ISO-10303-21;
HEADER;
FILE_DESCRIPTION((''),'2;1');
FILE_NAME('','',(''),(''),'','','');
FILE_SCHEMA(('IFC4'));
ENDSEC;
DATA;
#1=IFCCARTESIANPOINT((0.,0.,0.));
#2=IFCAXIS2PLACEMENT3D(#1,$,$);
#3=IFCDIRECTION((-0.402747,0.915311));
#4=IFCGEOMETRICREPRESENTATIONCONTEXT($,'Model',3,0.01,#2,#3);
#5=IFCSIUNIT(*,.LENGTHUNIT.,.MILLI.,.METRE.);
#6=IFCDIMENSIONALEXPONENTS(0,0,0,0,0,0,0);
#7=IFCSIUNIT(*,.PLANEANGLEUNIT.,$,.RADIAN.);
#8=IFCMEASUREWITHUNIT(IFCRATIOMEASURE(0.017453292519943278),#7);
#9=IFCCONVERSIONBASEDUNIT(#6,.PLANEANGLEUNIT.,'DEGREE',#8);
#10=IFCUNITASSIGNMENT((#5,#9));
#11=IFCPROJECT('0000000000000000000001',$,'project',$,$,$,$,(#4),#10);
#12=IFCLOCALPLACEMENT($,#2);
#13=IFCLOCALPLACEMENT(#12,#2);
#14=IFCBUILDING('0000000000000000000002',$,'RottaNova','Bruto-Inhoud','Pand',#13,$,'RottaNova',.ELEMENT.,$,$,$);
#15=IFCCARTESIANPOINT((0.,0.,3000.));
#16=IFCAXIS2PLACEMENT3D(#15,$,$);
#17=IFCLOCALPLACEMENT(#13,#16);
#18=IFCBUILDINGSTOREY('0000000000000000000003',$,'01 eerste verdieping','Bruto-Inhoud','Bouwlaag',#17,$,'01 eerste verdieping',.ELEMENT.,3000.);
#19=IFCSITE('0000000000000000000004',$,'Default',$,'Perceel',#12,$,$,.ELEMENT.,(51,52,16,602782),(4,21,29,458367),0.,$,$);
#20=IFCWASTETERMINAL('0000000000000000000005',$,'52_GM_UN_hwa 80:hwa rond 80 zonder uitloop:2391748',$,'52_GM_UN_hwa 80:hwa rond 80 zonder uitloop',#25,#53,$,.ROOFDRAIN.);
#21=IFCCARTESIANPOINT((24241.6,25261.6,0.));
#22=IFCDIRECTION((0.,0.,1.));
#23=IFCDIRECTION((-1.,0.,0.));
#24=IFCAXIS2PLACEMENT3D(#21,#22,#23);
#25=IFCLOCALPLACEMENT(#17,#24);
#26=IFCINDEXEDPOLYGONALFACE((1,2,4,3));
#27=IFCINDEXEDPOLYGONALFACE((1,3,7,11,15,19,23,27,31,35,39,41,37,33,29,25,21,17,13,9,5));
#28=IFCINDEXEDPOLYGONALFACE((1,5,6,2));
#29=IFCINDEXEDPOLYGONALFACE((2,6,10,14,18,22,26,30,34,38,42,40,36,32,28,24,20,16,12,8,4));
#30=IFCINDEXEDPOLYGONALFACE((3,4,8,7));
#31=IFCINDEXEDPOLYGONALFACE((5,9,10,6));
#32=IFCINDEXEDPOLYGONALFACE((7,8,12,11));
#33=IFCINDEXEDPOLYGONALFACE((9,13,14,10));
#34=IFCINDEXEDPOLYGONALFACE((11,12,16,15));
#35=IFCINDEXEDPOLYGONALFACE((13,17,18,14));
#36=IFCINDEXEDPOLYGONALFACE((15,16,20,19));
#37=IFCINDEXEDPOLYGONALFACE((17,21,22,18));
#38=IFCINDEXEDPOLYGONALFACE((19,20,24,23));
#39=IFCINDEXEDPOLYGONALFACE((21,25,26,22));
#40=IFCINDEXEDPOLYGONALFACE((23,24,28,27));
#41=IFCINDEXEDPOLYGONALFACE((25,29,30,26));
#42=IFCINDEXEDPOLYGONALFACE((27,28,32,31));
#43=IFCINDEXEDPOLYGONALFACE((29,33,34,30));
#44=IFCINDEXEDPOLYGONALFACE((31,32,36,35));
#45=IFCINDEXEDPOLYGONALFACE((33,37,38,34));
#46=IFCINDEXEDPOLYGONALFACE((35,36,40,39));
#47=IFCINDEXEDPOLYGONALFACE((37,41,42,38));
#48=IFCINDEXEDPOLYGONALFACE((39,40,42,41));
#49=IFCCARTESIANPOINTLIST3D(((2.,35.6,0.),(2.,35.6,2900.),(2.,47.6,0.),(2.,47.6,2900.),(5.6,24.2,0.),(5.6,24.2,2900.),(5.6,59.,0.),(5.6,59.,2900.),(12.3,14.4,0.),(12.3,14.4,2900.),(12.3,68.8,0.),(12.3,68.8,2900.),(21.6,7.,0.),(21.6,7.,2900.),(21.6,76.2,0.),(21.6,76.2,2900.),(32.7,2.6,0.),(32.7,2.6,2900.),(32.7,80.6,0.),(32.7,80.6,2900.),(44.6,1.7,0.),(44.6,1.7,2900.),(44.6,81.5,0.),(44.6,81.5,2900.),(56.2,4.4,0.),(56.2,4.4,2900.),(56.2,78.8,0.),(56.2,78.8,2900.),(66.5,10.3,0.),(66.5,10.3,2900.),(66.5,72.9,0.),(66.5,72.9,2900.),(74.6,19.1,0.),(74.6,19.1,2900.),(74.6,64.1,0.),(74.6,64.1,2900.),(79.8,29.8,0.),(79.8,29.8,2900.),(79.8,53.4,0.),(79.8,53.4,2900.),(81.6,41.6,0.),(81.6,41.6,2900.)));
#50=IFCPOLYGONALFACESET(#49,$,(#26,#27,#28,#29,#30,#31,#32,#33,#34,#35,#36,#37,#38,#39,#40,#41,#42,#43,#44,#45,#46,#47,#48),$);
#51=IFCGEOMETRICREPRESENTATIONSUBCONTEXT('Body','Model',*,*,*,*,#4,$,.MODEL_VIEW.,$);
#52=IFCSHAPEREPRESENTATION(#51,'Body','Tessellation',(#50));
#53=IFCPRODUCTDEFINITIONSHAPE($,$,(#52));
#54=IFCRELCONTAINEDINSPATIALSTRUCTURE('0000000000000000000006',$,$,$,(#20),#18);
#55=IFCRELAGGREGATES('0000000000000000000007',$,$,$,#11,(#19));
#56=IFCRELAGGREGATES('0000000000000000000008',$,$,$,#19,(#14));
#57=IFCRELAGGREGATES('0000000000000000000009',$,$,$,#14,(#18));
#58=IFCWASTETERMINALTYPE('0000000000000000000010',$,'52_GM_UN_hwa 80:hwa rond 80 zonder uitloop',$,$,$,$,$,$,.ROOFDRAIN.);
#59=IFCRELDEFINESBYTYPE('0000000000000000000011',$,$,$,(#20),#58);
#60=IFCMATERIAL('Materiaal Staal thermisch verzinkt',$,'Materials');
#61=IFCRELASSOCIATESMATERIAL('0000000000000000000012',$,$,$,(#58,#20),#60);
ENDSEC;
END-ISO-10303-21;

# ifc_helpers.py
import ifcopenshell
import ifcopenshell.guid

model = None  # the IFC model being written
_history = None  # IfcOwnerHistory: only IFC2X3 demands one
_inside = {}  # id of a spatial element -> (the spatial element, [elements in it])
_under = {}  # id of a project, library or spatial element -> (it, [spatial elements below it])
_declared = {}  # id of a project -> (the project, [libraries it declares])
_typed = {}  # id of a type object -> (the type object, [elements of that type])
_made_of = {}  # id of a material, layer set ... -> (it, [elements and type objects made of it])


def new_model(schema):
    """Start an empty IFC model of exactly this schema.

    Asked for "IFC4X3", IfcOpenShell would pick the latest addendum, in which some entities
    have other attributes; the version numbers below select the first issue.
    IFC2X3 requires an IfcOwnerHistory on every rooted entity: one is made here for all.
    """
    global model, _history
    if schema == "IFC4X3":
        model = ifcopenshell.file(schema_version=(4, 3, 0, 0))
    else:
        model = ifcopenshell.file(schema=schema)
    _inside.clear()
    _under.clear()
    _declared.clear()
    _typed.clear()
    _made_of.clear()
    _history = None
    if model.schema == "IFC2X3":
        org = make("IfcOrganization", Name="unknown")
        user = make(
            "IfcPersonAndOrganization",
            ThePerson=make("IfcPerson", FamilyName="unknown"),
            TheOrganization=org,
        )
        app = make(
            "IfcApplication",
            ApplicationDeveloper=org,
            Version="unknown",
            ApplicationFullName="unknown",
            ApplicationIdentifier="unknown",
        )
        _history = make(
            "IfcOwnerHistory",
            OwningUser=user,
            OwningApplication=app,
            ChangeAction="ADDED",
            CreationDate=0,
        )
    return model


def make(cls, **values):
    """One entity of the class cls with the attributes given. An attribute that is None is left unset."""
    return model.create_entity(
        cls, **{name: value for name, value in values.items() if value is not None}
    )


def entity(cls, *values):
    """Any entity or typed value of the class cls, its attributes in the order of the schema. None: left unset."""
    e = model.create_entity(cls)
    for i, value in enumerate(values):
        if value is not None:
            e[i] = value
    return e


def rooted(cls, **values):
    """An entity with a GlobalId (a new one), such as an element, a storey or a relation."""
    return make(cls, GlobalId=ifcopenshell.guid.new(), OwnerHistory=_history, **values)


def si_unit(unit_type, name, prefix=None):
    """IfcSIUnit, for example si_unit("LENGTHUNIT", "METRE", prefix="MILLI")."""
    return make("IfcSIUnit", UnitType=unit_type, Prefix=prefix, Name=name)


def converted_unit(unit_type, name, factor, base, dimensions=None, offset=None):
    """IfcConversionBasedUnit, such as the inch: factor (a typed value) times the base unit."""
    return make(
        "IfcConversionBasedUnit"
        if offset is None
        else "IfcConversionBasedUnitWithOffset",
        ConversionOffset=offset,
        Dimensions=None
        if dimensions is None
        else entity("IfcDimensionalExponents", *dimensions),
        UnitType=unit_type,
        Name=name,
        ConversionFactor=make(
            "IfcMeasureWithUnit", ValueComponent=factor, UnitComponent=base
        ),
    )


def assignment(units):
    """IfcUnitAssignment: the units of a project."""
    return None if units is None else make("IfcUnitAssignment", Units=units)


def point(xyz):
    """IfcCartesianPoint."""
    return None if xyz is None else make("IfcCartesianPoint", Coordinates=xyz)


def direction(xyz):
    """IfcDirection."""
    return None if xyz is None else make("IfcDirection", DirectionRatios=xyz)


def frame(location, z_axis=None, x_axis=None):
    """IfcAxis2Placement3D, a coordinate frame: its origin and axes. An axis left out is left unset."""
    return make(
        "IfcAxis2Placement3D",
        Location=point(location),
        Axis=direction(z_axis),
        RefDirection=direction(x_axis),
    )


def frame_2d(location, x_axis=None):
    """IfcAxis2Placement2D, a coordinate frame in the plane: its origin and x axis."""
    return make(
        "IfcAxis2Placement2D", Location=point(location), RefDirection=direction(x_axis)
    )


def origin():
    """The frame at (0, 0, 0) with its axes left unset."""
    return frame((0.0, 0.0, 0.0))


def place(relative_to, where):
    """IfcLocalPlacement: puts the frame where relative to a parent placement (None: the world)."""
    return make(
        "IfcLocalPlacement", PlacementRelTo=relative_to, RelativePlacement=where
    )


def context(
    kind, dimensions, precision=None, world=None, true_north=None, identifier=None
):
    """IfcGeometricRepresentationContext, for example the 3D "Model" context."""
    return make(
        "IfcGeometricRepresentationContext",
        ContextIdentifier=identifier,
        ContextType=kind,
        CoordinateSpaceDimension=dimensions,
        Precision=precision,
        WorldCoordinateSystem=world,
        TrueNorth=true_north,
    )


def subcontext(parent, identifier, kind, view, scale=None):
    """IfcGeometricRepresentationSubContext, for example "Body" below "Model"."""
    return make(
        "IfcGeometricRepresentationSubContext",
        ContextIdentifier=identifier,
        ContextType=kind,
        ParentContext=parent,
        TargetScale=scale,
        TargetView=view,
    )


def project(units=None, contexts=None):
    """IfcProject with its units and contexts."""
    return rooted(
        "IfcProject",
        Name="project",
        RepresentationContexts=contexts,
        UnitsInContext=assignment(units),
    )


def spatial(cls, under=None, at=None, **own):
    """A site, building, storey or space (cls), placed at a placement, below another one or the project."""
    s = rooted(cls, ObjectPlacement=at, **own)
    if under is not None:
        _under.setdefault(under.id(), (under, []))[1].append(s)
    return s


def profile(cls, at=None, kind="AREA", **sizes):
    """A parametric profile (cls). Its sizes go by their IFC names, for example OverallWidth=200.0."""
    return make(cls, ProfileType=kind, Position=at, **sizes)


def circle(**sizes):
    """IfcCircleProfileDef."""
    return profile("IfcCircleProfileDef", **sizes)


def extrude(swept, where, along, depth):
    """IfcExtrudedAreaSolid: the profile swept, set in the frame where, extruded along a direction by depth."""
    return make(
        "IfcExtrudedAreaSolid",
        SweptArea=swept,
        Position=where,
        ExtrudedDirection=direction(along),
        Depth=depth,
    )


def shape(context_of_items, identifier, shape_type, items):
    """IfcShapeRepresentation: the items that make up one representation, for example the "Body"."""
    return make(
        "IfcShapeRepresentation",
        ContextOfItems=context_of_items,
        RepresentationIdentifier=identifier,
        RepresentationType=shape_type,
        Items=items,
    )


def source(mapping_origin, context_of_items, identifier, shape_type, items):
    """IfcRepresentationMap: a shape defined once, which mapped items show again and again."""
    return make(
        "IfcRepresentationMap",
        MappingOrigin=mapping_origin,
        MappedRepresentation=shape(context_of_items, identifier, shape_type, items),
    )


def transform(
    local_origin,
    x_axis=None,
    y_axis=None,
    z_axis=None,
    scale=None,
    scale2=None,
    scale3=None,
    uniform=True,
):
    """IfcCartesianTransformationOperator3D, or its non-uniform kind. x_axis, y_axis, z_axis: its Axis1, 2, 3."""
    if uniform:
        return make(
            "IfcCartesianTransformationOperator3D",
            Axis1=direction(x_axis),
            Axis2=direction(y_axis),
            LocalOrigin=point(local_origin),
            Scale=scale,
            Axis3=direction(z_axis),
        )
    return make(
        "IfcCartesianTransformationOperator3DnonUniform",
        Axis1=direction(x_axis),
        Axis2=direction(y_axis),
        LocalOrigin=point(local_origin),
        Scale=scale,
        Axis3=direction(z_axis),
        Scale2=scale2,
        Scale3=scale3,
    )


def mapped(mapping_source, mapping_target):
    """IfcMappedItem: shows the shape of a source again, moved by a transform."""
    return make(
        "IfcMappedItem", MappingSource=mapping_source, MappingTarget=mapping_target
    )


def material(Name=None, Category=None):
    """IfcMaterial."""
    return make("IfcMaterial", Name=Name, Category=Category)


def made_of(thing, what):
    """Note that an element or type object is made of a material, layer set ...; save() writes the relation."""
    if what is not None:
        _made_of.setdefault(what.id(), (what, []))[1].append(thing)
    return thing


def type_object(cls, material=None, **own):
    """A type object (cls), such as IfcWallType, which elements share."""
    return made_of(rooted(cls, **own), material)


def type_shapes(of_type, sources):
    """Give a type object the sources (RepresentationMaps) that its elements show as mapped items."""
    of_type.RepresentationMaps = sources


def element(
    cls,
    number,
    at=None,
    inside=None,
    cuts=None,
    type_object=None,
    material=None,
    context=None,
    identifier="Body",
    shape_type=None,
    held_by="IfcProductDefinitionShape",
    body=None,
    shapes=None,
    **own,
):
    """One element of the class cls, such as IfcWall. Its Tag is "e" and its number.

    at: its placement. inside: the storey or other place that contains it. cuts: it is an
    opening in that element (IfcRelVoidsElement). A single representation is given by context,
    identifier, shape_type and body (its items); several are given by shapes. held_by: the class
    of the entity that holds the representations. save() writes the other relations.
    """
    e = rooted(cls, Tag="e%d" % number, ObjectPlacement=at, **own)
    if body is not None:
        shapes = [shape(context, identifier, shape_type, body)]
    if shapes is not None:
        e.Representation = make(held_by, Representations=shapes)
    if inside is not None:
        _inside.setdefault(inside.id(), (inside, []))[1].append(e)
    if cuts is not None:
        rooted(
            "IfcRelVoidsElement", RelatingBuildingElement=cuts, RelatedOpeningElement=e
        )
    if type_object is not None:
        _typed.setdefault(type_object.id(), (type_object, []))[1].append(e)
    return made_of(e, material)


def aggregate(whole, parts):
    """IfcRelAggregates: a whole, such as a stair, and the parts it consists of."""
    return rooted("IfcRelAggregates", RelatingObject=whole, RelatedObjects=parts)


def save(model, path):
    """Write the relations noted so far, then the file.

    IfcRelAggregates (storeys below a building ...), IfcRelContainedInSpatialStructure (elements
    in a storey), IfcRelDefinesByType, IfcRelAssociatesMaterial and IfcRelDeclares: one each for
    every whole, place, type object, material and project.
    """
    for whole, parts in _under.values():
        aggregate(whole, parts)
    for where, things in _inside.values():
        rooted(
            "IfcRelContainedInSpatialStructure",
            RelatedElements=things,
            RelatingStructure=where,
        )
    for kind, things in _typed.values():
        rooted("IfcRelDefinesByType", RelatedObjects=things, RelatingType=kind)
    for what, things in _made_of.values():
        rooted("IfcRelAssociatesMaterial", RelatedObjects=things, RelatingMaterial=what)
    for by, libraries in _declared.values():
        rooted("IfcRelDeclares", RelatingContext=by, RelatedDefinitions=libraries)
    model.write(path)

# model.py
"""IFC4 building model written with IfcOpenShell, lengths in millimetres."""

from ifc_helpers import new_model, entity, si_unit, converted_unit, direction, frame, frame_2d, origin, place, context, subcontext, project, spatial, circle, extrude, source, transform, mapped, material, type_object, type_shapes, element, save


model = new_model("IFC4")

# Units and contexts
model_context = context("Model", 3, precision=0.01, world=origin(), true_north=direction((-0.402747, 0.915311)))
body_context = subcontext(model_context, "Body", "Model", "MODEL_VIEW")
ifc_project = project(units=[si_unit("LENGTHUNIT", "METRE", prefix="MILLI"), converted_unit("PLANEANGLEUNIT", "DEGREE", entity("IfcRatioMeasure", 0.017453292519943278), si_unit("PLANEANGLEUNIT", "RADIAN"), dimensions=[0, 0, 0, 0, 0, 0, 0])], contexts=[model_context])

# Site, building, storey
site_placement = place(None, origin())
site = spatial("IfcSite", under=ifc_project, at=site_placement, Name="Default", ObjectType="Perceel", CompositionType="ELEMENT", RefLatitude=(51, 52, 16, 602782), RefLongitude=(4, 21, 29, 458367), RefElevation=0.0)
building_placement = place(site_placement, origin())
building = spatial("IfcBuilding", under=site, at=building_placement, Name="RottaNova", Description="Bruto-Inhoud", ObjectType="Pand", LongName="RottaNova", CompositionType="ELEMENT")
storey_placement = place(building_placement, frame((0.0, 0.0, 3000.0)))
storey = spatial("IfcBuildingStorey", under=building, at=storey_placement, Name="01 eerste verdieping", Description="Bruto-Inhoud", ObjectType="Bouwlaag", LongName="01 eerste verdieping", CompositionType="ELEMENT", Elevation=3000.0)

# Waste terminal
ifc_material_1 = material(Name="Materiaal Staal thermisch verzinkt", Category="Materials")
waste_terminal_type = type_object("IfcWasteTerminalType", Name="52_GM_UN_hwa 80:hwa rond 80 zonder uitloop", PredefinedType="ROOFDRAIN", material=ifc_material_1)
shared_shape_1 = source(origin(), body_context, "Body", "SweptSolid", [
    extrude(circle(Radius=40.0, at=frame_2d((0.0, 0.0), x_axis=(1.0, 0.0))), frame((41.6, 41.6, 0.0)), (0.0, 0.0, 1.0), 2900.0),
])
type_shapes(waste_terminal_type, [shared_shape_1])
waste_terminal_placement = place(storey_placement, frame((24241.6, 25261.6, 0.0), z_axis=(0.0, 0.0, 1.0), x_axis=(-1.0, 0.0, 0.0)))
element("IfcWasteTerminal", 1, at=waste_terminal_placement, inside=storey, type_object=waste_terminal_type, material=ifc_material_1, Name="52_GM_UN_hwa 80:hwa rond 80 zonder uitloop:2391748", ObjectType="52_GM_UN_hwa 80:hwa rond 80 zonder uitloop", PredefinedType="ROOFDRAIN", context=body_context, shape_type="MappedRepresentation", body=[
    mapped(shared_shape_1, transform((0.0, 0.0, 0.0), scale=1.0)),
])

save(model, "model.ifc")
